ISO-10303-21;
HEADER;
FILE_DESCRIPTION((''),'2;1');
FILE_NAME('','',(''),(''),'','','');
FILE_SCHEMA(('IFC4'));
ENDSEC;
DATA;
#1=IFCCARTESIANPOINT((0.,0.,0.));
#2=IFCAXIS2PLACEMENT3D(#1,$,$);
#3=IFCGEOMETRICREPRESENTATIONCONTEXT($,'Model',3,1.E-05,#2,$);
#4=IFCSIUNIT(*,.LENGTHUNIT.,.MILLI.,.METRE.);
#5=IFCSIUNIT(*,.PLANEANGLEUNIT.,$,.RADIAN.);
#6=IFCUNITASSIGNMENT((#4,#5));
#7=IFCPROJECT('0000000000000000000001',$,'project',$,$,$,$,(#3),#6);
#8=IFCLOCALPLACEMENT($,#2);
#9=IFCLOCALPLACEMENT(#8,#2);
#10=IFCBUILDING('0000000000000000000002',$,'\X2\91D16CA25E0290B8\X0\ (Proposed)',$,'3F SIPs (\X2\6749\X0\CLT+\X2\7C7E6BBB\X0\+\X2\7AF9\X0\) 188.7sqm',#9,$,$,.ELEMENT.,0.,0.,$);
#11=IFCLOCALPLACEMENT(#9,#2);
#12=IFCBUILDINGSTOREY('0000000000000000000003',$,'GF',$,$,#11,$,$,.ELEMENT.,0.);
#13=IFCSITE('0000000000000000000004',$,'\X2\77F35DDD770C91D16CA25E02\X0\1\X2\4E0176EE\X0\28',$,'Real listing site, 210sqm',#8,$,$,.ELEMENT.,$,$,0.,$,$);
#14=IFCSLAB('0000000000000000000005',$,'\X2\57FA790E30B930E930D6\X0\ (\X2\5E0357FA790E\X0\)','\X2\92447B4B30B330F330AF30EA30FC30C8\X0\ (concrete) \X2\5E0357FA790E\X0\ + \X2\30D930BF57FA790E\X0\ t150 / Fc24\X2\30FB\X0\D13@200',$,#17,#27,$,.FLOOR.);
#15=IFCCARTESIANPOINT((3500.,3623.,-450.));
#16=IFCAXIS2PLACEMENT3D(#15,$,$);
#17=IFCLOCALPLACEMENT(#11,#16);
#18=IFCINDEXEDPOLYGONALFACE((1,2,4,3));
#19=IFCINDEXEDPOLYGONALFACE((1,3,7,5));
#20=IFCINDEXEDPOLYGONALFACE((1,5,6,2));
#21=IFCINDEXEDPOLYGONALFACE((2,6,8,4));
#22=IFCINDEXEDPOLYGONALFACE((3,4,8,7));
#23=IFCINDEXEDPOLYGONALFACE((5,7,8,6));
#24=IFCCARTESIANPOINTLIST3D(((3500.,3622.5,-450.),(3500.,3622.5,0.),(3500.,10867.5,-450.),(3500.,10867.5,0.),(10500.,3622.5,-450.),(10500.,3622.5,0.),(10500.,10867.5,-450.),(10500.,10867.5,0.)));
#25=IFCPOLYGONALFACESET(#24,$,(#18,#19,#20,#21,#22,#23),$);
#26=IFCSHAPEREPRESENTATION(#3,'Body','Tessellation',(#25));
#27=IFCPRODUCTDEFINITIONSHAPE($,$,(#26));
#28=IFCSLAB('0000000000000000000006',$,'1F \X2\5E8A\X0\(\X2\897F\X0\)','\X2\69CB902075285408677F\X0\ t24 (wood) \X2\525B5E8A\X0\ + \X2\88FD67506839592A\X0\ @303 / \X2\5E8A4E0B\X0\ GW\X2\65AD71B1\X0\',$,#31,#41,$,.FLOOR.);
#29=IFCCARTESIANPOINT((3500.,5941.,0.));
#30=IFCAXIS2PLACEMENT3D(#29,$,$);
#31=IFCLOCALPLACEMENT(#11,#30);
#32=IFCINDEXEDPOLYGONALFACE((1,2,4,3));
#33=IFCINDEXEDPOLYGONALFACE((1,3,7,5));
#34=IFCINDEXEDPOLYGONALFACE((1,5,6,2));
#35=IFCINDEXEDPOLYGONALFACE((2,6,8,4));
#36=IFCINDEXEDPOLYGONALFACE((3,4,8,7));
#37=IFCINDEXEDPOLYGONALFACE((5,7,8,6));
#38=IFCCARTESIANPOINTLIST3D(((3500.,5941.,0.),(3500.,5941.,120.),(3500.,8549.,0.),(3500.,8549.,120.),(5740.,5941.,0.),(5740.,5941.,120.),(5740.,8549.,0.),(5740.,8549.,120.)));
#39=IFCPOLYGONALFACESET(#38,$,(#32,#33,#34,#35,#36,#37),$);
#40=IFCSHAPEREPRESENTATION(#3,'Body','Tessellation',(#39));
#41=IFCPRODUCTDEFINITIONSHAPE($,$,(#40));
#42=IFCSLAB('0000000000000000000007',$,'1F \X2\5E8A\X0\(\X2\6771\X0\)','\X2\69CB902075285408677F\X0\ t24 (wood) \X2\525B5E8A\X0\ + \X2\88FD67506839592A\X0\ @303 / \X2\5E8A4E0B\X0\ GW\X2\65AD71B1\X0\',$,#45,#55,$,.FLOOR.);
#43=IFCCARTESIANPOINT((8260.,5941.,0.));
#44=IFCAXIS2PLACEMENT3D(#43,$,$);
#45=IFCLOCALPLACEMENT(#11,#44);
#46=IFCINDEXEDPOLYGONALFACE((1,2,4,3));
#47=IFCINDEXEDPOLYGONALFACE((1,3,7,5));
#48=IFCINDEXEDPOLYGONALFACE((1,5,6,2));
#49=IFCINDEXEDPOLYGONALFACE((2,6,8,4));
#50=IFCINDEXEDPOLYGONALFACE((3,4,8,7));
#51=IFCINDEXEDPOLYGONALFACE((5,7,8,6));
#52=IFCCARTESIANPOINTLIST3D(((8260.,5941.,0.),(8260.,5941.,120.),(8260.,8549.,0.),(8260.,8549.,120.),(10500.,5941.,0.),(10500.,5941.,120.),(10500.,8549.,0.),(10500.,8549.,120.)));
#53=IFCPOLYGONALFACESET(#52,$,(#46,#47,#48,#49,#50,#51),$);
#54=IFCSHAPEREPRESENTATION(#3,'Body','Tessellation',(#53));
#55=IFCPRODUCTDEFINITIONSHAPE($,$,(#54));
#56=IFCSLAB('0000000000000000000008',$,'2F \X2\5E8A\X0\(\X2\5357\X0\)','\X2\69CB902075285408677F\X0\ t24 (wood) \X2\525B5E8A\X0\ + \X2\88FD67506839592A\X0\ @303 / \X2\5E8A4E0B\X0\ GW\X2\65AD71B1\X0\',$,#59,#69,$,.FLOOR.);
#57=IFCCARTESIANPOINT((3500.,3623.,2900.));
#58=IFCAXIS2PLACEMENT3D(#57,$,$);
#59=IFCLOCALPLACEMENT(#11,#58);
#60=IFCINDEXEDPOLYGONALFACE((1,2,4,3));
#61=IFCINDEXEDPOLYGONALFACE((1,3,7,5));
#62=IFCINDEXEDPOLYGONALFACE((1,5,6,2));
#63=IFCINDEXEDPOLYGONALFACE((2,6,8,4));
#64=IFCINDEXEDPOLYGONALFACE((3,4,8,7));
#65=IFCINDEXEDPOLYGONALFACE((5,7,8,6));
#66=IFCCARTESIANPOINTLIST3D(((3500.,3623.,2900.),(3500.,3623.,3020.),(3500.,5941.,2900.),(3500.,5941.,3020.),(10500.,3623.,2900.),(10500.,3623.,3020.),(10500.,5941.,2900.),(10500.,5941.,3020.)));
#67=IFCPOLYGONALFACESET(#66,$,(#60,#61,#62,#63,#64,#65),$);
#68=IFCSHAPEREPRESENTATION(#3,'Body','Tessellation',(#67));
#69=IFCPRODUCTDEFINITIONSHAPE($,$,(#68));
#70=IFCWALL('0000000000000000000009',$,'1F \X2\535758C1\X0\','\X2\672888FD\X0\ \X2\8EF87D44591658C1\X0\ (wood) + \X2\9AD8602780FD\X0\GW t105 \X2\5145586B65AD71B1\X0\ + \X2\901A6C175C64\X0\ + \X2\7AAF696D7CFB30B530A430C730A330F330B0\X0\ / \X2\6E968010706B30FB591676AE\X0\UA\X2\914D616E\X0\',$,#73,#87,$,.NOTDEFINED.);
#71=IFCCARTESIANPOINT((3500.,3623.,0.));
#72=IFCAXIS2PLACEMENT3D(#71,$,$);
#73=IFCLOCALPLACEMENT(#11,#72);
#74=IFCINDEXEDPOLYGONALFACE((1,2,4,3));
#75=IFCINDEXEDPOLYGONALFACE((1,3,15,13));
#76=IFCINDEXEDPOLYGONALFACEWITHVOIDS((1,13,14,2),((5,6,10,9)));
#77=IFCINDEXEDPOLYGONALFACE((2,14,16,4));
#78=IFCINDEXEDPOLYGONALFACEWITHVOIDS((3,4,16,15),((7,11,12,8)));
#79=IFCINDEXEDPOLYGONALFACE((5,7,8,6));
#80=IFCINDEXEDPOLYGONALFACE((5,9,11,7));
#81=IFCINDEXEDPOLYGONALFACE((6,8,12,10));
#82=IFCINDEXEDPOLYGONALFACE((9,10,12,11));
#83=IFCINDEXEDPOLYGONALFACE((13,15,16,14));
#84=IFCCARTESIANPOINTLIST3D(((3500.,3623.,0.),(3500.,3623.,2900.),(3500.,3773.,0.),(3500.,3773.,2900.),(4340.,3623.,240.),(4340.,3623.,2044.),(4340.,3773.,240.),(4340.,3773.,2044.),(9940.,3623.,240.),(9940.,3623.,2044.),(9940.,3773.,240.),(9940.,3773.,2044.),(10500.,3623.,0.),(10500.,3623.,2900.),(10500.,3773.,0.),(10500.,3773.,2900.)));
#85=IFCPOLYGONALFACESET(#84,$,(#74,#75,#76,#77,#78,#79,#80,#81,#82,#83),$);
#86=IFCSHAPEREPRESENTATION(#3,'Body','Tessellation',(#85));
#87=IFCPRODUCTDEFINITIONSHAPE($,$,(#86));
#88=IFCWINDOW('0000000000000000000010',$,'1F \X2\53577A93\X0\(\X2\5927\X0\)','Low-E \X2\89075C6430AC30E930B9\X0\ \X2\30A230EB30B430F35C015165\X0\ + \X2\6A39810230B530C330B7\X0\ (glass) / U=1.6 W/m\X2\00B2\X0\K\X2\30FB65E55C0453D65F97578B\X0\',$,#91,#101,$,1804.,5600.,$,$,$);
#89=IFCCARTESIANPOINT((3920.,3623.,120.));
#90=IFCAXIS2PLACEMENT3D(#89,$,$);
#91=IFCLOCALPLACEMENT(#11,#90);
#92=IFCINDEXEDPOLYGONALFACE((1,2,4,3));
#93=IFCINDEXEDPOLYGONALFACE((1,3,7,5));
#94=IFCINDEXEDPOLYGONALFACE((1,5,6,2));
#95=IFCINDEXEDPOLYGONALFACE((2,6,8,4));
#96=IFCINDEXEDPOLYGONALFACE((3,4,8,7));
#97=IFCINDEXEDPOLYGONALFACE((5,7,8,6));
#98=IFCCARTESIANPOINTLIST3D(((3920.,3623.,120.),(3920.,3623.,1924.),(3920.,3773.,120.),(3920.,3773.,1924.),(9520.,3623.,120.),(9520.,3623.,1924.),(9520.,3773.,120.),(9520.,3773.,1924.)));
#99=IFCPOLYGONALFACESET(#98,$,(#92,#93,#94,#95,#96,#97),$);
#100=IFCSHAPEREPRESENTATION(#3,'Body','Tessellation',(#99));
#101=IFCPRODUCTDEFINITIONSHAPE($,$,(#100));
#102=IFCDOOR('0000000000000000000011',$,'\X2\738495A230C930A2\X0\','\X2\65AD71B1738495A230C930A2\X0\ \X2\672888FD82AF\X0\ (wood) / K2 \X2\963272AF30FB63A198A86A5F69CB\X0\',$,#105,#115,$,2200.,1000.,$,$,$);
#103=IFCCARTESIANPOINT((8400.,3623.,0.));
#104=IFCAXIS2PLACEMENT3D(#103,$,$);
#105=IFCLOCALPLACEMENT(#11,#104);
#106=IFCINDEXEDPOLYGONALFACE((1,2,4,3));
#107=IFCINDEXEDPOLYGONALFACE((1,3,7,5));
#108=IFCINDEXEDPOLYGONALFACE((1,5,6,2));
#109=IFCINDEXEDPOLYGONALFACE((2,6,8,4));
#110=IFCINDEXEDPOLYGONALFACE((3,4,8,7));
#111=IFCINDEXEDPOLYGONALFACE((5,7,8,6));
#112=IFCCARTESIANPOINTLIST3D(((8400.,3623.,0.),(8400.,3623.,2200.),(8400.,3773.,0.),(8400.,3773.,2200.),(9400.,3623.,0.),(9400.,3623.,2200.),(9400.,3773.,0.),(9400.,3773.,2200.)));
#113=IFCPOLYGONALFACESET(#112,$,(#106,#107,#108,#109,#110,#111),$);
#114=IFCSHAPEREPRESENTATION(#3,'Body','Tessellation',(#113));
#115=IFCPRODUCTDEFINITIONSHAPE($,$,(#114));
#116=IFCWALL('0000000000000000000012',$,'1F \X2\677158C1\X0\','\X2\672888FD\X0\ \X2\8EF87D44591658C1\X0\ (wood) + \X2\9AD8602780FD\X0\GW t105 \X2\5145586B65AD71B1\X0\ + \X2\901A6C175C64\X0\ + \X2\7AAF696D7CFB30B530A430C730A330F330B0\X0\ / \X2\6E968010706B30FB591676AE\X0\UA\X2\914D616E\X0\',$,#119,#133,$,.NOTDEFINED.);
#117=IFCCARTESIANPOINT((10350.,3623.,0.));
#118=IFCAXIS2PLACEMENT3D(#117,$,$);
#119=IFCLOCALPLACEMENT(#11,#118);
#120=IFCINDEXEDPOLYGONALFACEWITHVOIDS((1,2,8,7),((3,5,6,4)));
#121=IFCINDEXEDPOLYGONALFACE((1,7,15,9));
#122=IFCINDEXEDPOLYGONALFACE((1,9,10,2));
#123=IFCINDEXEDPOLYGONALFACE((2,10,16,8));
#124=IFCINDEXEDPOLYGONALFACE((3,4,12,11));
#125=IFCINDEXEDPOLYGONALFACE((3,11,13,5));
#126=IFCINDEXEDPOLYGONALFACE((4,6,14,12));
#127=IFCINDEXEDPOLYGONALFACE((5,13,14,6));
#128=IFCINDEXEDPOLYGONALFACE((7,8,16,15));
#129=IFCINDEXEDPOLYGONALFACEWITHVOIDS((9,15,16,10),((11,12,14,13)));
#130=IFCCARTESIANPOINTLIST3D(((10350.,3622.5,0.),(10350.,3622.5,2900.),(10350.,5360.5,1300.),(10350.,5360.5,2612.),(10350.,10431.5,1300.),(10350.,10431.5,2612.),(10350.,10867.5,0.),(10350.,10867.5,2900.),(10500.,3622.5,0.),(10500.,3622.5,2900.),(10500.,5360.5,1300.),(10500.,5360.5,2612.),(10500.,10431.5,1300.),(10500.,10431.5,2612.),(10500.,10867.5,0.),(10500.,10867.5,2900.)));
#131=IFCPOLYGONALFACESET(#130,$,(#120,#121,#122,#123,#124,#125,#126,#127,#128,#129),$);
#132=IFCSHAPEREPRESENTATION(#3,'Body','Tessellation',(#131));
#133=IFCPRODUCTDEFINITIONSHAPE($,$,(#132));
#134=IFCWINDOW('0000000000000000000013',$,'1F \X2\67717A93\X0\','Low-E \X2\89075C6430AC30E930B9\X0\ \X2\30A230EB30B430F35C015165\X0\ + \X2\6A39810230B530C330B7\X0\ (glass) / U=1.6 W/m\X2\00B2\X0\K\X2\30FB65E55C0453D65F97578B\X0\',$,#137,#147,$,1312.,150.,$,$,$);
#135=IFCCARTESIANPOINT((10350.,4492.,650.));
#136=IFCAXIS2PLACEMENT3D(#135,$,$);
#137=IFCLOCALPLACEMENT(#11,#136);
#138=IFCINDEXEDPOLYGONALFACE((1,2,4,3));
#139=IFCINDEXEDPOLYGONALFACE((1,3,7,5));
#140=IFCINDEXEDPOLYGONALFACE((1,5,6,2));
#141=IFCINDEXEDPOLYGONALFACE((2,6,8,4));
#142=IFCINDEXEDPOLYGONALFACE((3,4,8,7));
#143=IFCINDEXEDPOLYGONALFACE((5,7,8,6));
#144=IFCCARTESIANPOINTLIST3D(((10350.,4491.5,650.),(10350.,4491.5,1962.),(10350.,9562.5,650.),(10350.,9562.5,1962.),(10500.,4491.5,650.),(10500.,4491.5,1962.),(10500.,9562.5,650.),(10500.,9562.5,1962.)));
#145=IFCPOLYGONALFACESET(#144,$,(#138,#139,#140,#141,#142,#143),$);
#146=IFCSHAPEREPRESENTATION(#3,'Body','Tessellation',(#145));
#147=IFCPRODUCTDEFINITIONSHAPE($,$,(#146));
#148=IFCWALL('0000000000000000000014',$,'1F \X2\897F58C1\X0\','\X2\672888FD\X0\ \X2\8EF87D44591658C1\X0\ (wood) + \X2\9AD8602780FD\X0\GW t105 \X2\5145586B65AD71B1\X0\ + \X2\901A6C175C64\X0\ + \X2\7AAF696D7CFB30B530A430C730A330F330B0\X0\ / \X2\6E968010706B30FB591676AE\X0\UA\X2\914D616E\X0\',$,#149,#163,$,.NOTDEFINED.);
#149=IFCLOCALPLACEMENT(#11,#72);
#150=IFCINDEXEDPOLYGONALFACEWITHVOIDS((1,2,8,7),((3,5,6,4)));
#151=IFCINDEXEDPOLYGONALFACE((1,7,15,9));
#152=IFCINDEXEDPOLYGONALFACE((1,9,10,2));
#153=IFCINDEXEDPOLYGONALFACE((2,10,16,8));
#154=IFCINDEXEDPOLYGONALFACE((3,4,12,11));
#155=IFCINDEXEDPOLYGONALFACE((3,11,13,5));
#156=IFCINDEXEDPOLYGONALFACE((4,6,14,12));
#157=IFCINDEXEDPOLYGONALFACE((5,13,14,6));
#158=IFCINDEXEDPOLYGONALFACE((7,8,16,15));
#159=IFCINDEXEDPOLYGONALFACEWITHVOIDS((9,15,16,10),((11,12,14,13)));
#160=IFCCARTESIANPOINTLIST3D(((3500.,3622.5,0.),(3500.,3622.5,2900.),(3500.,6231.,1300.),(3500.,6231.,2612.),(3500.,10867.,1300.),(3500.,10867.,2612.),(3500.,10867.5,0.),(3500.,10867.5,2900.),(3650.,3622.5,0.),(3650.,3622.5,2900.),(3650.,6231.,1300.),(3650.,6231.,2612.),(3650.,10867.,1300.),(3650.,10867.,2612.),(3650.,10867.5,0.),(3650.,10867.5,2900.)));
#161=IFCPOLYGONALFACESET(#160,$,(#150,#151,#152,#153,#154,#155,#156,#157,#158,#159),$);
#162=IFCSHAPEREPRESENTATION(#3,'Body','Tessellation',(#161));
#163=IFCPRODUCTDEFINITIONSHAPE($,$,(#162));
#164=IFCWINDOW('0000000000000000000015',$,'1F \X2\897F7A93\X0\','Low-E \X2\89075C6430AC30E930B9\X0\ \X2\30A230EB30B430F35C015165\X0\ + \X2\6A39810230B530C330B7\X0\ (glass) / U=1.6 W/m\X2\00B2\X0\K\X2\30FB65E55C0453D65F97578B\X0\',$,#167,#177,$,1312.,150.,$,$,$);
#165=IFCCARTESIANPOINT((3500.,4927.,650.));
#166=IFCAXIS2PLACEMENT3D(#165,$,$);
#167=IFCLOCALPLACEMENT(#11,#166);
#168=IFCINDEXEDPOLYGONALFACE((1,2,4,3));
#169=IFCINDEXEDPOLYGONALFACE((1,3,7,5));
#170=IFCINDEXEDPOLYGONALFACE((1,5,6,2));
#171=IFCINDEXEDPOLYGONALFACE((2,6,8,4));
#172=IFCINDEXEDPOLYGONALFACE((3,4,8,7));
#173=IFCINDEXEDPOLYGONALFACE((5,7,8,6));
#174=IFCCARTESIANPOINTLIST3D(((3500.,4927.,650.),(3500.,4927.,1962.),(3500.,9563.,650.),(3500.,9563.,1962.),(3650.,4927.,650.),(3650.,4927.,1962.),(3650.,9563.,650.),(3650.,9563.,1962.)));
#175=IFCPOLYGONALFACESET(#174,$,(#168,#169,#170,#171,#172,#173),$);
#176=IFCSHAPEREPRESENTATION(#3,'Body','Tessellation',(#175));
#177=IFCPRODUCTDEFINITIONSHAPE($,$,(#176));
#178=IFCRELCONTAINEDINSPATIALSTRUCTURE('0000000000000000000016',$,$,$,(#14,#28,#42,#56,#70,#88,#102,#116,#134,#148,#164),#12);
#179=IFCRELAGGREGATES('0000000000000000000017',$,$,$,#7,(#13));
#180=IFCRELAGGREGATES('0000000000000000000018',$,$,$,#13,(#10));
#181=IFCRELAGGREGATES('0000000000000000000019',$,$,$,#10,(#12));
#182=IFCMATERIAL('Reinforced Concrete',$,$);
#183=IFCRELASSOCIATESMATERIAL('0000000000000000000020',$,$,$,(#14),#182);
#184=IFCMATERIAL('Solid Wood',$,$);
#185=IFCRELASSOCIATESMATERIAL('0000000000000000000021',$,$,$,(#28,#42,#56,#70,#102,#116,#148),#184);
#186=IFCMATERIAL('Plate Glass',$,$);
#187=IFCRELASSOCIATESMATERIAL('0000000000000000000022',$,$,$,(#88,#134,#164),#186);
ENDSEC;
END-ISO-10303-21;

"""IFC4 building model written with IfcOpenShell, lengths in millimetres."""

from ifc_helpers import new_model, si_unit, frame, frame_2d, origin, place, context, project, spatial, rectangle, extrude, material, element, fill, save


model = new_model("IFC4")

# Units and contexts
model_context = context("Model", 3, precision=1e-05, world=origin())
ifc_project = project(units=[si_unit("LENGTHUNIT", "METRE", prefix="MILLI"), si_unit("PLANEANGLEUNIT", "RADIAN")], contexts=[model_context])

# Site, building, storey
site_placement = place(None, origin())
site = spatial("IfcSite", under=ifc_project, at=site_placement, Name="石川県金沢市1丁目28", ObjectType="Real listing site, 210sqm", CompositionType="ELEMENT", RefElevation=0.0)
building_placement = place(site_placement, origin())
building = spatial("IfcBuilding", under=site, at=building_placement, Name="金沢市邸 (Proposed)", ObjectType="3F SIPs (杉CLT+籾殻+竹) 188.7sqm", CompositionType="ELEMENT", ElevationOfRefHeight=0.0, ElevationOfTerrain=0.0)
storey_placement = place(building_placement, origin())
storey = spatial("IfcBuildingStorey", under=building, at=storey_placement, Name="GF", CompositionType="ELEMENT", Elevation=0.0)

# Slabs
ifc_material_1 = material(Name="Reinforced Concrete")
slab_1_placement = place(storey_placement, frame((3500.0, 3623.0, -450.0)))
element("IfcSlab", 1, at=slab_1_placement, inside=storey, material=ifc_material_1, Name="基礎スラブ (布基礎)", Description="鉄筋コンクリート (concrete) 布基礎 + ベタ基礎 t150 / Fc24・D13@200", PredefinedType="FLOOR", context=model_context, shape_type="SweptSolid", body=[
    extrude(rectangle(XDim=7000.0, YDim=7245.0, at=frame_2d((3500.0, 3622.0))), frame((3500.0, 3623.0, -450.0)), (0.0, 0.0, 1.0), 450.0),
])
ifc_material_2 = material(Name="Solid Wood")
slab_2_placement = place(storey_placement, frame((3500.0, 5941.0, 0.0)))
element("IfcSlab", 2, at=slab_2_placement, inside=storey, material=ifc_material_2, Name="1F 床(西)", Description="構造用合板 t24 (wood) 剛床 + 製材根太 @303 / 床下 GW断熱", PredefinedType="FLOOR", context=model_context, shape_type="SweptSolid", body=[
    extrude(rectangle(XDim=2240.0, YDim=2608.0, at=frame_2d((1120.0, 1304.0))), frame((3500.0, 5941.0, 0.0)), (0.0, 0.0, 1.0), 120.0),
])
slab_3_placement = place(storey_placement, frame((8260.0, 5941.0, 0.0)))
element("IfcSlab", 3, at=slab_3_placement, inside=storey, material=ifc_material_2, Name="1F 床(東)", Description="構造用合板 t24 (wood) 剛床 + 製材根太 @303 / 床下 GW断熱", PredefinedType="FLOOR", context=model_context, shape_type="SweptSolid", body=[
    extrude(rectangle(XDim=2240.0, YDim=2608.0, at=frame_2d((1120.0, 1304.0))), frame((8260.0, 5941.0, 0.0)), (0.0, 0.0, 1.0), 120.0),
])
slab_4_placement = place(storey_placement, frame((3500.0, 3623.0, 2900.0)))
element("IfcSlab", 4, at=slab_4_placement, inside=storey, material=ifc_material_2, Name="2F 床(南)", Description="構造用合板 t24 (wood) 剛床 + 製材根太 @303 / 床下 GW断熱", PredefinedType="FLOOR", context=model_context, shape_type="SweptSolid", body=[
    extrude(rectangle(XDim=7000.0, YDim=2318.0, at=frame_2d((3500.0, 1159.0))), frame((3500.0, 3623.0, 2900.0)), (0.0, 0.0, 1.0), 120.0),
])

# Wall, openings, window, door
wall_1_placement = place(storey_placement, frame((3500.0, 3623.0, 0.0)))
wall_1 = element("IfcWall", 5, at=wall_1_placement, inside=storey, material=ifc_material_2, Name="1F 南壁", Description="木製 軸組外壁 (wood) + 高性能GW t105 充填断熱 + 通気層 + 窯業系サイディング / 準耐火・外皮UA配慮", PredefinedType="NOTDEFINED", context=model_context, shape_type="SweptSolid", body=[
    extrude(rectangle(XDim=7000.0, YDim=150.0, at=frame_2d((3500.0, 75.0))), frame((3500.0, 3623.0, 0.0)), (0.0, 0.0, 1.0), 2900.0),
])
opening_1_placement = place(storey_placement, frame((3920.0, 3623.0, 120.0)))
opening_1 = element("IfcOpeningElement", 6, at=opening_1_placement, cuts=wall_1, PredefinedType="NOTDEFINED", context=model_context, shape_type="SweptSolid", body=[
    extrude(rectangle(XDim=5600.0, YDim=150.0, at=frame_2d((2800.0, 75.0))), frame((3920.0, 3623.0, 120.0)), (0.0, 0.0, 1.0), 1804.0),
])
opening_2_placement = place(storey_placement, frame((8400.0, 3623.0, 0.0)))
opening_2 = element("IfcOpeningElement", 7, at=opening_2_placement, cuts=wall_1, PredefinedType="NOTDEFINED", context=model_context, shape_type="SweptSolid", body=[
    extrude(rectangle(XDim=1000.0, YDim=150.0, at=frame_2d((500.0, 75.0))), frame((8400.0, 3623.0, 0.0)), (0.0, 0.0, 1.0), 2200.0),
])
ifc_material_3 = material(Name="Plate Glass")
window_1_placement = place(storey_placement, frame((3920.0, 3623.0, 120.0)))
window_1 = element("IfcWindow", 8, at=window_1_placement, inside=storey, material=ifc_material_3, Name="1F 南窓(大)", Description="Low-E 複層ガラス アルゴン封入 + 樹脂サッシ (glass) / U=1.6 W/m²K・日射取得型", OverallHeight=1804.0, OverallWidth=5600.0, context=model_context, shape_type="SweptSolid", body=[
    extrude(rectangle(XDim=5600.0, YDim=150.0, at=frame_2d((2800.0, 75.0))), frame((3920.0, 3623.0, 120.0)), (0.0, 0.0, 1.0), 1804.0),
])
fill(opening_1, window_1)
door_placement = place(storey_placement, frame((8400.0, 3623.0, 0.0)))
door = element("IfcDoor", 9, at=door_placement, inside=storey, material=ifc_material_2, Name="玄関ドア", Description="断熱玄関ドア 木製芯 (wood) / K2 防犯・採風機構", OverallHeight=2200.0, OverallWidth=1000.0, context=model_context, shape_type="SweptSolid", body=[
    extrude(rectangle(XDim=1000.0, YDim=150.0, at=frame_2d((500.0, 75.0))), frame((8400.0, 3623.0, 0.0)), (0.0, 0.0, 1.0), 2200.0),
])
fill(opening_2, door)

# Walls, openings, windows
wall_2_placement = place(storey_placement, frame((10350.0, 3623.0, 0.0)))
wall_2 = element("IfcWall", 10, at=wall_2_placement, inside=storey, material=ifc_material_2, Name="1F 東壁", Description="木製 軸組外壁 (wood) + 高性能GW t105 充填断熱 + 通気層 + 窯業系サイディング / 準耐火・外皮UA配慮", PredefinedType="NOTDEFINED", context=model_context, shape_type="SweptSolid", body=[
    extrude(rectangle(XDim=150.0, YDim=7245.0, at=frame_2d((75.0, 3622.0))), frame((10350.0, 3623.0, 0.0)), (0.0, 0.0, 1.0), 2900.0),
])
opening_3_placement = place(storey_placement, frame((10350.0, 4492.0, 650.0)))
opening_3 = element("IfcOpeningElement", 11, at=opening_3_placement, cuts=wall_2, PredefinedType="NOTDEFINED", context=model_context, shape_type="SweptSolid", body=[
    extrude(rectangle(XDim=150.0, YDim=5071.0, at=frame_2d((75.0, 2535.0))), frame((10350.0, 4492.0, 650.0)), (0.0, 0.0, 1.0), 1312.0),
])
window_2_placement = place(storey_placement, frame((10350.0, 4492.0, 650.0)))
window_2 = element("IfcWindow", 12, at=window_2_placement, inside=storey, material=ifc_material_3, Name="1F 東窓", Description="Low-E 複層ガラス アルゴン封入 + 樹脂サッシ (glass) / U=1.6 W/m²K・日射取得型", OverallHeight=1312.0, OverallWidth=150.0, context=model_context, shape_type="SweptSolid", body=[
    extrude(rectangle(XDim=150.0, YDim=5071.0, at=frame_2d((75.0, 2535.0))), frame((10350.0, 4492.0, 650.0)), (0.0, 0.0, 1.0), 1312.0),
])
fill(opening_3, window_2)
wall_3_placement = place(storey_placement, frame((3500.0, 3623.0, 0.0)))
wall_3 = element("IfcWall", 13, at=wall_3_placement, inside=storey, material=ifc_material_2, Name="1F 西壁", Description="木製 軸組外壁 (wood) + 高性能GW t105 充填断熱 + 通気層 + 窯業系サイディング / 準耐火・外皮UA配慮", PredefinedType="NOTDEFINED", context=model_context, shape_type="SweptSolid", body=[
    extrude(rectangle(XDim=150.0, YDim=7245.0, at=frame_2d((75.0, 3622.0))), frame((3500.0, 3623.0, 0.0)), (0.0, 0.0, 1.0), 2900.0),
])
opening_4_placement = place(storey_placement, frame((3500.0, 4927.0, 650.0)))
opening_4 = element("IfcOpeningElement", 14, at=opening_4_placement, cuts=wall_3, PredefinedType="NOTDEFINED", context=model_context, shape_type="SweptSolid", body=[
    extrude(rectangle(XDim=150.0, YDim=4636.0, at=frame_2d((75.0, 2318.0))), frame((3500.0, 4927.0, 650.0)), (0.0, 0.0, 1.0), 1312.0),
])
window_3_placement = place(storey_placement, frame((3500.0, 4927.0, 650.0)))
window_3 = element("IfcWindow", 15, at=window_3_placement, inside=storey, material=ifc_material_3, Name="1F 西窓", Description="Low-E 複層ガラス アルゴン封入 + 樹脂サッシ (glass) / U=1.6 W/m²K・日射取得型", OverallHeight=1312.0, OverallWidth=150.0, context=model_context, shape_type="SweptSolid", body=[
    extrude(rectangle(XDim=150.0, YDim=4636.0, at=frame_2d((75.0, 2318.0))), frame((3500.0, 4927.0, 650.0)), (0.0, 0.0, 1.0), 1312.0),
])
fill(opening_4, window_3)

save(model, "model.ifc")
